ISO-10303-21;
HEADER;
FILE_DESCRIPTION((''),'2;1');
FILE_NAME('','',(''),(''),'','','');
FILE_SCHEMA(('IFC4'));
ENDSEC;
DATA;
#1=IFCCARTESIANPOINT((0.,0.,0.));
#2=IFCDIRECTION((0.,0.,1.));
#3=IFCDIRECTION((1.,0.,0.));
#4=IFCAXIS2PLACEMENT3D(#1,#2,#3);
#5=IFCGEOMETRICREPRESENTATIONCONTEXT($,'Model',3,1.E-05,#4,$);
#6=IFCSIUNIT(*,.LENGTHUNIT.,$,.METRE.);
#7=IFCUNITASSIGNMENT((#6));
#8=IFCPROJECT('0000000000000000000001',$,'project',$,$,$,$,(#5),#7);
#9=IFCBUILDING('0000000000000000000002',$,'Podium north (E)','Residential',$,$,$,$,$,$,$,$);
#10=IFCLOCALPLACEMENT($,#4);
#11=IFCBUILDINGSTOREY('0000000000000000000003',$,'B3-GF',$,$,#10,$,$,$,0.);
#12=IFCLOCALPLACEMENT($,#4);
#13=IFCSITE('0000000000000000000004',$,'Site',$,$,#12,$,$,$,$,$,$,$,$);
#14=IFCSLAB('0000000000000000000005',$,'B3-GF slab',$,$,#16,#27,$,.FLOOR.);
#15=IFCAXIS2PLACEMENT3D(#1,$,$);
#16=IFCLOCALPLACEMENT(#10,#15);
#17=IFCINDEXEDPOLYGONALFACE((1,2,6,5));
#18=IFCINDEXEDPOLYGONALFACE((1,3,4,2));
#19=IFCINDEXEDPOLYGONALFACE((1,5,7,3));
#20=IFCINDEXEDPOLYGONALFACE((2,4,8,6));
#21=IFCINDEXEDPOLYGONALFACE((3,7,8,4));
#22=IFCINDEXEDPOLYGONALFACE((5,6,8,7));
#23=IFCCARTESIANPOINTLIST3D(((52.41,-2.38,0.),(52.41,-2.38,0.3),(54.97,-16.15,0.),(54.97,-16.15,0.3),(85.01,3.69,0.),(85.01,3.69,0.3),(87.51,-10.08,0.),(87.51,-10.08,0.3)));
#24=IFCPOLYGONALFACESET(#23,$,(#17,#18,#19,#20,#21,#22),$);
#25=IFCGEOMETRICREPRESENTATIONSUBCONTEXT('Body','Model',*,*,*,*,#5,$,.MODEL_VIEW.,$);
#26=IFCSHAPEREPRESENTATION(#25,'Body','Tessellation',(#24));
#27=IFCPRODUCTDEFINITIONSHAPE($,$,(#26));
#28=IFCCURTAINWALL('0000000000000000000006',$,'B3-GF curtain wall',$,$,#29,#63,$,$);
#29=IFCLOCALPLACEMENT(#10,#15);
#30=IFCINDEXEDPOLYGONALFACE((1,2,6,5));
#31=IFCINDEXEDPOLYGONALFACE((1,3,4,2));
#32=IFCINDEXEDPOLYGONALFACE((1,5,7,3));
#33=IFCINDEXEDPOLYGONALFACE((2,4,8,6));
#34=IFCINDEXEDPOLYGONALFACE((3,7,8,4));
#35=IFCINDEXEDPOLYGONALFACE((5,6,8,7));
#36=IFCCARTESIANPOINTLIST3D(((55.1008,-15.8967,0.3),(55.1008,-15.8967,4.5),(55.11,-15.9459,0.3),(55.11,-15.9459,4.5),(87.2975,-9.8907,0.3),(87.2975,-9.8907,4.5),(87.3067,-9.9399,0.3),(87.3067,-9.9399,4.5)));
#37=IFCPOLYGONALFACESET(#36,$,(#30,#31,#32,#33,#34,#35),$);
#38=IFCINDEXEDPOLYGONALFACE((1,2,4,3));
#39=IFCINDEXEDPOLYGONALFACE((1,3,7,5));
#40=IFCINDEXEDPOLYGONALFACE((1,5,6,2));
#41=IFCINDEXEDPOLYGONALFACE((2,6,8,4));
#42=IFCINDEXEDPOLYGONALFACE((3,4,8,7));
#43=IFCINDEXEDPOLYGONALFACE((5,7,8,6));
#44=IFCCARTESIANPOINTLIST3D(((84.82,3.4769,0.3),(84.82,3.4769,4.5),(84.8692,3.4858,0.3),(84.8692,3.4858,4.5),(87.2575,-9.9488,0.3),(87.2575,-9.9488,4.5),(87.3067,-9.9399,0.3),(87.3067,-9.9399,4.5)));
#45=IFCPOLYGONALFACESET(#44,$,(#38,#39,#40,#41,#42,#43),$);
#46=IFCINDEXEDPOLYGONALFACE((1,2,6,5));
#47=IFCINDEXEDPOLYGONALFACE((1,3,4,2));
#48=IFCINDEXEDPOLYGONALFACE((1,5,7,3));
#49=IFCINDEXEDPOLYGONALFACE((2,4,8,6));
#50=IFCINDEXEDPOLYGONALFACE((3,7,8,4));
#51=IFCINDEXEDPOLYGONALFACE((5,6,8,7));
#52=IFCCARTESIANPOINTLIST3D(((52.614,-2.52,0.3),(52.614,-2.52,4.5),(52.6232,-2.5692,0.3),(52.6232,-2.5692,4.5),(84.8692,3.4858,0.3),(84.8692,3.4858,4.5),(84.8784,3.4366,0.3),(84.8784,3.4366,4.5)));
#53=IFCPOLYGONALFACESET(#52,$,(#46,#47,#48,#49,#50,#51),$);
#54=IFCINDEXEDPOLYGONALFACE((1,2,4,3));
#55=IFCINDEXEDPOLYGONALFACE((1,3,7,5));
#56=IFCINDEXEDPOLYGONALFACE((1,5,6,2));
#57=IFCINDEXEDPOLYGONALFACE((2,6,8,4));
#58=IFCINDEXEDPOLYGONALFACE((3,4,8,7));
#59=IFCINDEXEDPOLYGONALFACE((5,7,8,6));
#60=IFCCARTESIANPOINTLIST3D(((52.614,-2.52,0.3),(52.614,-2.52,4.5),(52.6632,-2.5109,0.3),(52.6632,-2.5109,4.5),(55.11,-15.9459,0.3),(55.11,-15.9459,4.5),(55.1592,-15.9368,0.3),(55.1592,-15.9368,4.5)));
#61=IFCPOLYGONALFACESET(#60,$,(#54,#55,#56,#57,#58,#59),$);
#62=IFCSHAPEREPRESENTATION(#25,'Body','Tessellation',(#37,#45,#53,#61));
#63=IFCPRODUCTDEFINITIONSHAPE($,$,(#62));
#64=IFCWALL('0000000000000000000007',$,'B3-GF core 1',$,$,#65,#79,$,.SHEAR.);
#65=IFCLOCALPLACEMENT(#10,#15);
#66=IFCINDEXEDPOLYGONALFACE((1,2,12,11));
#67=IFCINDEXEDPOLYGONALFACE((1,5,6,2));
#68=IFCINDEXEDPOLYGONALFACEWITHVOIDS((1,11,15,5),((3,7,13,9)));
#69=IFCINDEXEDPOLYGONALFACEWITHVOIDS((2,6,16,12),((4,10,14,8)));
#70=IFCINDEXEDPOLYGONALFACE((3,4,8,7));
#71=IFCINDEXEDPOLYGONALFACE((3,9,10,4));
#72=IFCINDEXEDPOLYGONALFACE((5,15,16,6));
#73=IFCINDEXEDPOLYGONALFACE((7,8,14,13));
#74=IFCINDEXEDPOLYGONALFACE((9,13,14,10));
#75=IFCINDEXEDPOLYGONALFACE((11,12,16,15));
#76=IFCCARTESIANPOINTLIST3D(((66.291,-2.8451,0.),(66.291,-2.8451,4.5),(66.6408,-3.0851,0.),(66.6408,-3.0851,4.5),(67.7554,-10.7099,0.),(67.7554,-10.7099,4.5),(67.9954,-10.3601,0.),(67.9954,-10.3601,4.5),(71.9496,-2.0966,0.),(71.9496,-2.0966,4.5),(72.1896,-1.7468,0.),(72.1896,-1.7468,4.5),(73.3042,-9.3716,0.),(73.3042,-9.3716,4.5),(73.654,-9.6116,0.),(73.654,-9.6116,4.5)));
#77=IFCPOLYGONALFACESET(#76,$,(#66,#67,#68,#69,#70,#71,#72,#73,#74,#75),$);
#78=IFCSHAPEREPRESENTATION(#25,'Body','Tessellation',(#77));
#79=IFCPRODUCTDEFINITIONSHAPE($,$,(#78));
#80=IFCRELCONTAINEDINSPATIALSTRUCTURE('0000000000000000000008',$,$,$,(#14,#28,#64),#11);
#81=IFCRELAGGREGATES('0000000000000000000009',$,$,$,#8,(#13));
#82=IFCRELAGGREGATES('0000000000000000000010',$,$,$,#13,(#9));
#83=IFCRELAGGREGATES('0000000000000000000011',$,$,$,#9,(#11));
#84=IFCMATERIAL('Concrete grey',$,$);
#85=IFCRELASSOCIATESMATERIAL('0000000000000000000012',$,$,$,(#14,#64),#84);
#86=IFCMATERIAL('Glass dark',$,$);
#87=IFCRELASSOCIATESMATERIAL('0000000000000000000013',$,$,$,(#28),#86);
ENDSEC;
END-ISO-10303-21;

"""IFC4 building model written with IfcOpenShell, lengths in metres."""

from ifc_helpers import new_model, si_unit, frame, origin_with_axes, place, context, subcontext, project, spatial, polyline, outline, extrude, material, element, save


model = new_model("IFC4")

# Units and contexts
model_context = context("Model", 3, precision=1e-05, world=origin_with_axes())
body_context = subcontext(model_context, "Body", "Model", "MODEL_VIEW")
ifc_project = project(units=[si_unit("LENGTHUNIT", "METRE")], contexts=[model_context])

# Site, building, storey
site_placement = place(None, origin_with_axes())
site = spatial("IfcSite", under=ifc_project, at=site_placement, Name="Site")
building = spatial("IfcBuilding", under=site, Name="Podium north (E)", Description="Residential")
storey_placement = place(None, origin_with_axes())
storey = spatial("IfcBuildingStorey", under=building, at=storey_placement, Name="B3-GF", Elevation=0.0)

# Slab
ifc_material_1 = material(Name="Concrete grey")
slab_placement = place(storey_placement, origin_with_axes())
element("IfcSlab", 1, at=slab_placement, inside=storey, material=ifc_material_1, Name="B3-GF slab", PredefinedType="FLOOR", context=body_context, shape_type="SweptSolid", body=[
    extrude(outline(polyline([(54.97, -16.15), (87.51, -10.08), (85.01, 3.69), (52.41, -2.38), (54.97, -16.15)])), origin_with_axes(), (0.0, 0.0, 1.0), 0.3),
])

# Curtain wall
ifc_material_2 = material(Name="Glass dark")
curtain_wall_placement = place(storey_placement, origin_with_axes())
element("IfcCurtainWall", 2, at=curtain_wall_placement, inside=storey, material=ifc_material_2, Name="B3-GF curtain wall", context=body_context, shape_type="SweptSolid", body=[
    extrude(outline(polyline([(55.11, -15.9459), (87.3067, -9.9399), (87.2975, -9.8907), (55.1008, -15.8967), (55.11, -15.9459)])), frame((0.0, 0.0, 0.3), z_axis=(0.0, 0.0, 1.0), x_axis=(1.0, 0.0, 0.0)), (0.0, 0.0, 1.0), 4.2),
    extrude(outline(polyline([(87.3067, -9.9399), (84.8692, 3.4858), (84.82, 3.4769), (87.2575, -9.9488), (87.3067, -9.9399)])), frame((0.0, 0.0, 0.3), z_axis=(0.0, 0.0, 1.0), x_axis=(1.0, 0.0, 0.0)), (0.0, 0.0, 1.0), 4.2),
    extrude(outline(polyline([(84.8692, 3.4858), (52.614, -2.52), (52.6232, -2.5692), (84.8784, 3.4366), (84.8692, 3.4858)])), frame((0.0, 0.0, 0.3), z_axis=(0.0, 0.0, 1.0), x_axis=(1.0, 0.0, 0.0)), (0.0, 0.0, 1.0), 4.2),
    extrude(outline(polyline([(52.614, -2.52), (55.11, -15.9459), (55.1592, -15.9368), (52.6632, -2.5109), (52.614, -2.52)])), frame((0.0, 0.0, 0.3), z_axis=(0.0, 0.0, 1.0), x_axis=(1.0, 0.0, 0.0)), (0.0, 0.0, 1.0), 4.2),
])

# Wall
wall_placement = place(storey_placement, origin_with_axes())
element("IfcWall", 3, at=wall_placement, inside=storey, material=ifc_material_1, Name="B3-GF core 1", PredefinedType="SHEAR", context=body_context, shape_type="SweptSolid", body=[
    extrude(outline(polyline([(72.1896, -1.7468), (66.291, -2.8451), (67.7554, -10.7099), (73.654, -9.6116), (72.1896, -1.7468)]), holes=[polyline([(71.9496, -2.0966), (66.6408, -3.0851), (67.9954, -10.3601), (73.3042, -9.3716), (71.9496, -2.0966)])]), origin_with_axes(), (0.0, 0.0, 1.0), 4.5),
])

save(model, "model.ifc")
